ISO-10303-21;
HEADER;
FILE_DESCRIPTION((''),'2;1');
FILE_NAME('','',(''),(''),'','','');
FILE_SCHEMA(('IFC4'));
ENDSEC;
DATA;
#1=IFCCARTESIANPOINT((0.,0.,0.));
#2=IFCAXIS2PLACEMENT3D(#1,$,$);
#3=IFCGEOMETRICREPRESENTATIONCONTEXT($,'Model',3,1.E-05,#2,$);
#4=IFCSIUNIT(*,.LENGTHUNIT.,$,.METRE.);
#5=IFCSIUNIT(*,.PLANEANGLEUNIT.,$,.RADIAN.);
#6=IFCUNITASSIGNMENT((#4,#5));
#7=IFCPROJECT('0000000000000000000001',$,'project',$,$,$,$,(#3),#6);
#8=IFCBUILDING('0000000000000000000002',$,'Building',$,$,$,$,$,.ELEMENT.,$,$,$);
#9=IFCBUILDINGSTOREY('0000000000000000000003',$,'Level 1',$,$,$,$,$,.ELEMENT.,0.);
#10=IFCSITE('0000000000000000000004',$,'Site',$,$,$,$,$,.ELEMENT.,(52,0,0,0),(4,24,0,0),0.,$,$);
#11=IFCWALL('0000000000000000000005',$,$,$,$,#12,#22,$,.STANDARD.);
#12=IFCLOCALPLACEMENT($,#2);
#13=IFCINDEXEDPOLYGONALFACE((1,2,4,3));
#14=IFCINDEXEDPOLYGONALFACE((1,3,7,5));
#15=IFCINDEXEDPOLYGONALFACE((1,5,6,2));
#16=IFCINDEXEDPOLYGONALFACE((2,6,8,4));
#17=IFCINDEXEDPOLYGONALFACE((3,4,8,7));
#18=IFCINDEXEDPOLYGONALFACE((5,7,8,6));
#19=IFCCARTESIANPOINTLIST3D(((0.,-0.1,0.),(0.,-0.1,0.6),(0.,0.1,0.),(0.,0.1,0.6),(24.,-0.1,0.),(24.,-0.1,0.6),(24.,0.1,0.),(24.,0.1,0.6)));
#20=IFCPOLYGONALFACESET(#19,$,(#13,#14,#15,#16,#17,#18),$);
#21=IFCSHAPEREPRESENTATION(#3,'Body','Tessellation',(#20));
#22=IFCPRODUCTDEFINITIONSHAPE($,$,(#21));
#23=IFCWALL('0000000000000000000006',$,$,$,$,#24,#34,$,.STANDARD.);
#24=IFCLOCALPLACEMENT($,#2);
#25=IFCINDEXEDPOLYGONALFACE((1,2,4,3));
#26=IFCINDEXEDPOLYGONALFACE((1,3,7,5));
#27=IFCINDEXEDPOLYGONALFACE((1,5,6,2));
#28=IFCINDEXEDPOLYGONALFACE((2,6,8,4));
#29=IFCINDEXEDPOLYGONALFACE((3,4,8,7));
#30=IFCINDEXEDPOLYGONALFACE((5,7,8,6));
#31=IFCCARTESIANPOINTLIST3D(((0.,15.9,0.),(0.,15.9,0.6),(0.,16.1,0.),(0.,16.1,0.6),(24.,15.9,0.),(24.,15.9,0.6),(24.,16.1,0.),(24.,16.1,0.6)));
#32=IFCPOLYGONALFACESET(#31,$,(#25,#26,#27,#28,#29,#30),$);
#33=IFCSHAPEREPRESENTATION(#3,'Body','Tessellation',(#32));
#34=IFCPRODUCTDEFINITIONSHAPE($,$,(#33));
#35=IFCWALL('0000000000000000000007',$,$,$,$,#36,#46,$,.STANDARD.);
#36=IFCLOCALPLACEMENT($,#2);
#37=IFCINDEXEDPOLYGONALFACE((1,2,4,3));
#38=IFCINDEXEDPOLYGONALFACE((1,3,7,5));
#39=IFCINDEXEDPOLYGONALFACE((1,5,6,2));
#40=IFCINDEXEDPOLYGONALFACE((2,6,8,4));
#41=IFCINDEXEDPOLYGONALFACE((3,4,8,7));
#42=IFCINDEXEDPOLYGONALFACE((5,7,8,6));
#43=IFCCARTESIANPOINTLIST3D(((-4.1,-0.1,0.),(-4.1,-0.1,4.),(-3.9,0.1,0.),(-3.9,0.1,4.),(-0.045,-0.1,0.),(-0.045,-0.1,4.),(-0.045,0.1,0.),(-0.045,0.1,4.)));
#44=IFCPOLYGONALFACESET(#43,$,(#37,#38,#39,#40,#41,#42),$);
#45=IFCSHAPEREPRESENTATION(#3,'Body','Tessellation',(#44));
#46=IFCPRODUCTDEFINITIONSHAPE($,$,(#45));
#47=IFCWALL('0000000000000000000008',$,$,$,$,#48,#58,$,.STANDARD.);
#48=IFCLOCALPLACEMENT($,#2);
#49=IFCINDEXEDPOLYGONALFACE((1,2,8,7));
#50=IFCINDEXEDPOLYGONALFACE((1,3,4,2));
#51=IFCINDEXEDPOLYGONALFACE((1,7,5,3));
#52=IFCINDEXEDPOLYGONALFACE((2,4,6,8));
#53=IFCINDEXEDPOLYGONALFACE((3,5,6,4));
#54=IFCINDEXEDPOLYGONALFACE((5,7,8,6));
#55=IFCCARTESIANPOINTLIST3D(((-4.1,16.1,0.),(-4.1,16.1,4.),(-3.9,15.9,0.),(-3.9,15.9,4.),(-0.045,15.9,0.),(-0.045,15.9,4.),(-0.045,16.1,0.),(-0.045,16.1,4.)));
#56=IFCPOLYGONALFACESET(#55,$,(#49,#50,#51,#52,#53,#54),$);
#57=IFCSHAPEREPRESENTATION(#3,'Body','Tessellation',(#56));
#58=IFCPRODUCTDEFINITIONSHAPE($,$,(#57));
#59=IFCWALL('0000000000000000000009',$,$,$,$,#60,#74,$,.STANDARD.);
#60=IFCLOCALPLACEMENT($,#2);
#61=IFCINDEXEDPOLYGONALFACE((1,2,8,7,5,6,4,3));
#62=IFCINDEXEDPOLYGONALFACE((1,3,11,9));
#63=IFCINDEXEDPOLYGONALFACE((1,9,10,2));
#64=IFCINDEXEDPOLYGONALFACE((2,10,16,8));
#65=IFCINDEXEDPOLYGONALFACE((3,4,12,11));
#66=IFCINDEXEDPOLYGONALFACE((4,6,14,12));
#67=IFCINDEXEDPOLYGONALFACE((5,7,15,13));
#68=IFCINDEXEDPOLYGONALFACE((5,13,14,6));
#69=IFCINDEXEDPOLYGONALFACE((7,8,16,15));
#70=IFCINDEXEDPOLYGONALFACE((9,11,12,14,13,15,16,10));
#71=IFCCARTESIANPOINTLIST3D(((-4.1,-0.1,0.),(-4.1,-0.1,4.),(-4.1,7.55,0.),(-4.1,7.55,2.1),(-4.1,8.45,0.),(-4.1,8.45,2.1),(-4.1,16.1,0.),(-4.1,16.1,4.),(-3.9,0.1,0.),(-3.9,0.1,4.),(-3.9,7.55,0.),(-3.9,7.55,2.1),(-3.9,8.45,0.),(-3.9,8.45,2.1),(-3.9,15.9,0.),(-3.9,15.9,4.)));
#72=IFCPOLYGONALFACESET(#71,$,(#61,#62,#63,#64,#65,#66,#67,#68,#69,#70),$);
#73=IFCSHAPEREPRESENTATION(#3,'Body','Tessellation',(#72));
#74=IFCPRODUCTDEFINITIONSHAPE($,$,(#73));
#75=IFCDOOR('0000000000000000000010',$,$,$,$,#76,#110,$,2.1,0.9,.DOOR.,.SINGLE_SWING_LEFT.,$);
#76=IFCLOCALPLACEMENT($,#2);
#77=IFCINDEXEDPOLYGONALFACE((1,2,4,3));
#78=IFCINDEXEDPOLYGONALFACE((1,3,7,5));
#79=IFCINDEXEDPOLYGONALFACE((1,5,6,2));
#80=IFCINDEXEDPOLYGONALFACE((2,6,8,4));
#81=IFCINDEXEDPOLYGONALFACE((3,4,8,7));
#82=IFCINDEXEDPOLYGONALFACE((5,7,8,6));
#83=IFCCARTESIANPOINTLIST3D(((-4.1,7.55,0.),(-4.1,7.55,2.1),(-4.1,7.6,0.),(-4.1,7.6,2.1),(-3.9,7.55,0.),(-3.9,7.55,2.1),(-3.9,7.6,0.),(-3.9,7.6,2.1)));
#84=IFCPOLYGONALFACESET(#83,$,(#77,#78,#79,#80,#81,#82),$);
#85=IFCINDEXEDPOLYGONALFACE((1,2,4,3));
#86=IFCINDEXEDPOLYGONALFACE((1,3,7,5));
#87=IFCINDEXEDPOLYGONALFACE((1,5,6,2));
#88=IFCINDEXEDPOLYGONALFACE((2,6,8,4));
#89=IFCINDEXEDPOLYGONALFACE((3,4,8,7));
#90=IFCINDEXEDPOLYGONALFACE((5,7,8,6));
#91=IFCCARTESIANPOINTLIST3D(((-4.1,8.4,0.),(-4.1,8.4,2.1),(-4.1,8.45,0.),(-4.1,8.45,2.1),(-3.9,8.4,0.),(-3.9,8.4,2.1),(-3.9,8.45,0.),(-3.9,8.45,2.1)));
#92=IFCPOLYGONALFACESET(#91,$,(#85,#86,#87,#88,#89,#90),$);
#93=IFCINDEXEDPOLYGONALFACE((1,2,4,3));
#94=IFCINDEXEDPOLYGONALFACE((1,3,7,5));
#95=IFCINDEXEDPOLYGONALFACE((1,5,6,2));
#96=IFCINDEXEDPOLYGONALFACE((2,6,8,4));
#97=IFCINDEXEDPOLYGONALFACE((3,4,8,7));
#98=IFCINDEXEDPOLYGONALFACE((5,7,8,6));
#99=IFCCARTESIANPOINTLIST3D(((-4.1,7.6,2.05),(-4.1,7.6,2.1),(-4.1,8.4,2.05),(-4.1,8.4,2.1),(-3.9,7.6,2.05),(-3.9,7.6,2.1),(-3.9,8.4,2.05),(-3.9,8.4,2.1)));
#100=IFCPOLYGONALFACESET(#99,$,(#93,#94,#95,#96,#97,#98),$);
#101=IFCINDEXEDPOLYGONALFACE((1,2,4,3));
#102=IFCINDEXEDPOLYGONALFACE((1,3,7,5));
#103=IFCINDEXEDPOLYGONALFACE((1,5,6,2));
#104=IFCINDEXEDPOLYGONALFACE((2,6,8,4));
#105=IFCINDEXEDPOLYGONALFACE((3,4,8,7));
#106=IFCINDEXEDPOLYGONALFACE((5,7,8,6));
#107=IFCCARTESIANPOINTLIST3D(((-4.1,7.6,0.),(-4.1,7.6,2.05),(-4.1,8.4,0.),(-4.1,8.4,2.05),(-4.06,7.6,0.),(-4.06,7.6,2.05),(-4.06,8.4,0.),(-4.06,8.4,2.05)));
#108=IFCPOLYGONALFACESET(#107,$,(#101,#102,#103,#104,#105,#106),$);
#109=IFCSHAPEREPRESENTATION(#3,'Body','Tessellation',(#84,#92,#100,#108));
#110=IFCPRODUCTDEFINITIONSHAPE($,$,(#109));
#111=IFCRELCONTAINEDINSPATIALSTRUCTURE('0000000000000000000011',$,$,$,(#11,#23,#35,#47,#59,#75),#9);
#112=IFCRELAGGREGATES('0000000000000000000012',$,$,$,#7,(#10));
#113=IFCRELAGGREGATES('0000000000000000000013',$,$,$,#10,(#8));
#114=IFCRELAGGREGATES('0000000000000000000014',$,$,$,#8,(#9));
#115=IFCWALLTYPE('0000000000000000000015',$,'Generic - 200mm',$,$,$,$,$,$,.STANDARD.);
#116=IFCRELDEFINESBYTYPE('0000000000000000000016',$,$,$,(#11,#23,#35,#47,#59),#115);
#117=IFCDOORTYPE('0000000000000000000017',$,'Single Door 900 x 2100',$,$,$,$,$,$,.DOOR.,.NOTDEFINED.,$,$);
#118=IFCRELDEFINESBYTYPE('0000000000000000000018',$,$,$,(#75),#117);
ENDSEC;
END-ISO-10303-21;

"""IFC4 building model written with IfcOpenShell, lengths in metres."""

from ifc_helpers import new_model, si_unit, frame, frame_2d, origin, origin_with_axes, origin_2d, place, context, project, spatial, polyline, rectangle, outline, extrude, type_object, element, fill, save


model = new_model("IFC4")

# Units and contexts
model_context = context("Model", 3, precision=1e-05, world=origin())
ifc_project = project(units=[si_unit("LENGTHUNIT", "METRE"), si_unit("PLANEANGLEUNIT", "RADIAN")], contexts=[model_context])

# Site, building, storey
site = spatial("IfcSite", under=ifc_project, Name="Site", CompositionType="ELEMENT", RefLatitude=(52, 0, 0, 0), RefLongitude=(4, 24, 0, 0), RefElevation=0.0)
building = spatial("IfcBuilding", under=site, Name="Building", CompositionType="ELEMENT")
storey = spatial("IfcBuildingStorey", under=building, Name="Level 1", CompositionType="ELEMENT", Elevation=0.0)

# Walls
wall_type = type_object("IfcWallType", Name="Generic - 200mm", PredefinedType="STANDARD")
for number, where, z_axis, x_axis in (
    (1, (0.0, 0.0, 0.0), (0.0, 0.0, 1.0), (1.0, 0.0, 0.0)),
    (2, (24.0, 16.0, 0.0), (0.0, 0.0, 1.0), (-1.0, 0.0, 0.0)),
):
    element("IfcWall", number, at=place(None, frame(where, z_axis=z_axis, x_axis=x_axis)), inside=storey, type_object=wall_type, PredefinedType="STANDARD", context=model_context, shape_type="SweptSolid", body=[
        extrude(rectangle(XDim=24.0, YDim=0.2, at=frame_2d((12.0, 0.0))), origin(), (0.0, 0.0, 1.0), 0.6),
    ])
wall_1_placement = place(None, frame((-0.045, 0.0, 0.0), z_axis=(0.0, 0.0, 1.0), x_axis=(-1.0, 0.0, 0.0)))
element("IfcWall", 3, at=wall_1_placement, inside=storey, type_object=wall_type, PredefinedType="STANDARD", context=model_context, shape_type="SweptSolid", body=[
    extrude(outline(polyline([(0.0, -0.1), (3.855, -0.1), (4.055, 0.1), (0.0, 0.1), (0.0, -0.1)])), origin(), (0.0, 0.0, 1.0), 4.0),
])
wall_2_placement = place(None, frame((-4.0, 16.0, 0.0), z_axis=(0.0, 0.0, 1.0), x_axis=(1.0, 0.0, 0.0)))
element("IfcWall", 4, at=wall_2_placement, inside=storey, type_object=wall_type, PredefinedType="STANDARD", context=model_context, shape_type="SweptSolid", body=[
    extrude(outline(polyline([(0.1, -0.1), (3.955, -0.1), (3.955, 0.1), (-0.1, 0.1), (0.1, -0.1)])), origin(), (0.0, 0.0, 1.0), 4.0),
])

# Wall, opening, door
wall_3_placement = place(None, frame((-4.0, 0.0, 0.0), z_axis=(0.0, 0.0, 1.0), x_axis=(0.0, 1.0, 0.0)))
wall_3 = element("IfcWall", 5, at=wall_3_placement, inside=storey, type_object=wall_type, PredefinedType="STANDARD", context=model_context, shape_type="SweptSolid", body=[
    extrude(outline(polyline([(0.1, -0.1), (15.9, -0.1), (16.1, 0.1), (-0.1, 0.1), (0.1, -0.1)])), origin(), (0.0, 0.0, 1.0), 4.0),
])
opening_placement = place(wall_3_placement, frame((8.0, 0.0, 0.0), z_axis=(0.0, 0.0, 1.0), x_axis=(1.0, 0.0, 0.0)))
opening = element("IfcOpeningElement", 6, at=opening_placement, cuts=wall_3, PredefinedType="OPENING", context=model_context, shape_type="SweptSolid", body=[
    extrude(rectangle(XDim=0.9, YDim=0.202, at=origin_2d()), origin(), (0.0, 0.0, 1.0), 2.1),
])
door_type = type_object("IfcDoorType", Name="Single Door 900 x 2100", OperationType="NOTDEFINED", PredefinedType="DOOR")
door_placement = place(opening_placement, origin_with_axes())
door = element("IfcDoor", 7, at=door_placement, inside=storey, type_object=door_type, OperationType="SINGLE_SWING_LEFT", OverallHeight=2.1, OverallWidth=0.9, PredefinedType="DOOR", context=model_context, shape_type="SweptSolid", body=[
    extrude(rectangle(XDim=0.05, YDim=0.2, at=frame_2d((-0.425, 0.0))), origin(), (0.0, 0.0, 1.0), 2.1),
    extrude(rectangle(XDim=0.05, YDim=0.2, at=frame_2d((0.425, 0.0))), origin(), (0.0, 0.0, 1.0), 2.1),
    extrude(rectangle(XDim=0.8, YDim=0.2, at=origin_2d()), frame((0.0, 0.0, 2.05)), (0.0, 0.0, 1.0), 0.05),
    extrude(rectangle(XDim=0.8, YDim=0.04, at=frame_2d((0.0, 0.08))), origin(), (0.0, 0.0, 1.0), 2.05),
])
fill(opening, door)

save(model, "model.ifc")
